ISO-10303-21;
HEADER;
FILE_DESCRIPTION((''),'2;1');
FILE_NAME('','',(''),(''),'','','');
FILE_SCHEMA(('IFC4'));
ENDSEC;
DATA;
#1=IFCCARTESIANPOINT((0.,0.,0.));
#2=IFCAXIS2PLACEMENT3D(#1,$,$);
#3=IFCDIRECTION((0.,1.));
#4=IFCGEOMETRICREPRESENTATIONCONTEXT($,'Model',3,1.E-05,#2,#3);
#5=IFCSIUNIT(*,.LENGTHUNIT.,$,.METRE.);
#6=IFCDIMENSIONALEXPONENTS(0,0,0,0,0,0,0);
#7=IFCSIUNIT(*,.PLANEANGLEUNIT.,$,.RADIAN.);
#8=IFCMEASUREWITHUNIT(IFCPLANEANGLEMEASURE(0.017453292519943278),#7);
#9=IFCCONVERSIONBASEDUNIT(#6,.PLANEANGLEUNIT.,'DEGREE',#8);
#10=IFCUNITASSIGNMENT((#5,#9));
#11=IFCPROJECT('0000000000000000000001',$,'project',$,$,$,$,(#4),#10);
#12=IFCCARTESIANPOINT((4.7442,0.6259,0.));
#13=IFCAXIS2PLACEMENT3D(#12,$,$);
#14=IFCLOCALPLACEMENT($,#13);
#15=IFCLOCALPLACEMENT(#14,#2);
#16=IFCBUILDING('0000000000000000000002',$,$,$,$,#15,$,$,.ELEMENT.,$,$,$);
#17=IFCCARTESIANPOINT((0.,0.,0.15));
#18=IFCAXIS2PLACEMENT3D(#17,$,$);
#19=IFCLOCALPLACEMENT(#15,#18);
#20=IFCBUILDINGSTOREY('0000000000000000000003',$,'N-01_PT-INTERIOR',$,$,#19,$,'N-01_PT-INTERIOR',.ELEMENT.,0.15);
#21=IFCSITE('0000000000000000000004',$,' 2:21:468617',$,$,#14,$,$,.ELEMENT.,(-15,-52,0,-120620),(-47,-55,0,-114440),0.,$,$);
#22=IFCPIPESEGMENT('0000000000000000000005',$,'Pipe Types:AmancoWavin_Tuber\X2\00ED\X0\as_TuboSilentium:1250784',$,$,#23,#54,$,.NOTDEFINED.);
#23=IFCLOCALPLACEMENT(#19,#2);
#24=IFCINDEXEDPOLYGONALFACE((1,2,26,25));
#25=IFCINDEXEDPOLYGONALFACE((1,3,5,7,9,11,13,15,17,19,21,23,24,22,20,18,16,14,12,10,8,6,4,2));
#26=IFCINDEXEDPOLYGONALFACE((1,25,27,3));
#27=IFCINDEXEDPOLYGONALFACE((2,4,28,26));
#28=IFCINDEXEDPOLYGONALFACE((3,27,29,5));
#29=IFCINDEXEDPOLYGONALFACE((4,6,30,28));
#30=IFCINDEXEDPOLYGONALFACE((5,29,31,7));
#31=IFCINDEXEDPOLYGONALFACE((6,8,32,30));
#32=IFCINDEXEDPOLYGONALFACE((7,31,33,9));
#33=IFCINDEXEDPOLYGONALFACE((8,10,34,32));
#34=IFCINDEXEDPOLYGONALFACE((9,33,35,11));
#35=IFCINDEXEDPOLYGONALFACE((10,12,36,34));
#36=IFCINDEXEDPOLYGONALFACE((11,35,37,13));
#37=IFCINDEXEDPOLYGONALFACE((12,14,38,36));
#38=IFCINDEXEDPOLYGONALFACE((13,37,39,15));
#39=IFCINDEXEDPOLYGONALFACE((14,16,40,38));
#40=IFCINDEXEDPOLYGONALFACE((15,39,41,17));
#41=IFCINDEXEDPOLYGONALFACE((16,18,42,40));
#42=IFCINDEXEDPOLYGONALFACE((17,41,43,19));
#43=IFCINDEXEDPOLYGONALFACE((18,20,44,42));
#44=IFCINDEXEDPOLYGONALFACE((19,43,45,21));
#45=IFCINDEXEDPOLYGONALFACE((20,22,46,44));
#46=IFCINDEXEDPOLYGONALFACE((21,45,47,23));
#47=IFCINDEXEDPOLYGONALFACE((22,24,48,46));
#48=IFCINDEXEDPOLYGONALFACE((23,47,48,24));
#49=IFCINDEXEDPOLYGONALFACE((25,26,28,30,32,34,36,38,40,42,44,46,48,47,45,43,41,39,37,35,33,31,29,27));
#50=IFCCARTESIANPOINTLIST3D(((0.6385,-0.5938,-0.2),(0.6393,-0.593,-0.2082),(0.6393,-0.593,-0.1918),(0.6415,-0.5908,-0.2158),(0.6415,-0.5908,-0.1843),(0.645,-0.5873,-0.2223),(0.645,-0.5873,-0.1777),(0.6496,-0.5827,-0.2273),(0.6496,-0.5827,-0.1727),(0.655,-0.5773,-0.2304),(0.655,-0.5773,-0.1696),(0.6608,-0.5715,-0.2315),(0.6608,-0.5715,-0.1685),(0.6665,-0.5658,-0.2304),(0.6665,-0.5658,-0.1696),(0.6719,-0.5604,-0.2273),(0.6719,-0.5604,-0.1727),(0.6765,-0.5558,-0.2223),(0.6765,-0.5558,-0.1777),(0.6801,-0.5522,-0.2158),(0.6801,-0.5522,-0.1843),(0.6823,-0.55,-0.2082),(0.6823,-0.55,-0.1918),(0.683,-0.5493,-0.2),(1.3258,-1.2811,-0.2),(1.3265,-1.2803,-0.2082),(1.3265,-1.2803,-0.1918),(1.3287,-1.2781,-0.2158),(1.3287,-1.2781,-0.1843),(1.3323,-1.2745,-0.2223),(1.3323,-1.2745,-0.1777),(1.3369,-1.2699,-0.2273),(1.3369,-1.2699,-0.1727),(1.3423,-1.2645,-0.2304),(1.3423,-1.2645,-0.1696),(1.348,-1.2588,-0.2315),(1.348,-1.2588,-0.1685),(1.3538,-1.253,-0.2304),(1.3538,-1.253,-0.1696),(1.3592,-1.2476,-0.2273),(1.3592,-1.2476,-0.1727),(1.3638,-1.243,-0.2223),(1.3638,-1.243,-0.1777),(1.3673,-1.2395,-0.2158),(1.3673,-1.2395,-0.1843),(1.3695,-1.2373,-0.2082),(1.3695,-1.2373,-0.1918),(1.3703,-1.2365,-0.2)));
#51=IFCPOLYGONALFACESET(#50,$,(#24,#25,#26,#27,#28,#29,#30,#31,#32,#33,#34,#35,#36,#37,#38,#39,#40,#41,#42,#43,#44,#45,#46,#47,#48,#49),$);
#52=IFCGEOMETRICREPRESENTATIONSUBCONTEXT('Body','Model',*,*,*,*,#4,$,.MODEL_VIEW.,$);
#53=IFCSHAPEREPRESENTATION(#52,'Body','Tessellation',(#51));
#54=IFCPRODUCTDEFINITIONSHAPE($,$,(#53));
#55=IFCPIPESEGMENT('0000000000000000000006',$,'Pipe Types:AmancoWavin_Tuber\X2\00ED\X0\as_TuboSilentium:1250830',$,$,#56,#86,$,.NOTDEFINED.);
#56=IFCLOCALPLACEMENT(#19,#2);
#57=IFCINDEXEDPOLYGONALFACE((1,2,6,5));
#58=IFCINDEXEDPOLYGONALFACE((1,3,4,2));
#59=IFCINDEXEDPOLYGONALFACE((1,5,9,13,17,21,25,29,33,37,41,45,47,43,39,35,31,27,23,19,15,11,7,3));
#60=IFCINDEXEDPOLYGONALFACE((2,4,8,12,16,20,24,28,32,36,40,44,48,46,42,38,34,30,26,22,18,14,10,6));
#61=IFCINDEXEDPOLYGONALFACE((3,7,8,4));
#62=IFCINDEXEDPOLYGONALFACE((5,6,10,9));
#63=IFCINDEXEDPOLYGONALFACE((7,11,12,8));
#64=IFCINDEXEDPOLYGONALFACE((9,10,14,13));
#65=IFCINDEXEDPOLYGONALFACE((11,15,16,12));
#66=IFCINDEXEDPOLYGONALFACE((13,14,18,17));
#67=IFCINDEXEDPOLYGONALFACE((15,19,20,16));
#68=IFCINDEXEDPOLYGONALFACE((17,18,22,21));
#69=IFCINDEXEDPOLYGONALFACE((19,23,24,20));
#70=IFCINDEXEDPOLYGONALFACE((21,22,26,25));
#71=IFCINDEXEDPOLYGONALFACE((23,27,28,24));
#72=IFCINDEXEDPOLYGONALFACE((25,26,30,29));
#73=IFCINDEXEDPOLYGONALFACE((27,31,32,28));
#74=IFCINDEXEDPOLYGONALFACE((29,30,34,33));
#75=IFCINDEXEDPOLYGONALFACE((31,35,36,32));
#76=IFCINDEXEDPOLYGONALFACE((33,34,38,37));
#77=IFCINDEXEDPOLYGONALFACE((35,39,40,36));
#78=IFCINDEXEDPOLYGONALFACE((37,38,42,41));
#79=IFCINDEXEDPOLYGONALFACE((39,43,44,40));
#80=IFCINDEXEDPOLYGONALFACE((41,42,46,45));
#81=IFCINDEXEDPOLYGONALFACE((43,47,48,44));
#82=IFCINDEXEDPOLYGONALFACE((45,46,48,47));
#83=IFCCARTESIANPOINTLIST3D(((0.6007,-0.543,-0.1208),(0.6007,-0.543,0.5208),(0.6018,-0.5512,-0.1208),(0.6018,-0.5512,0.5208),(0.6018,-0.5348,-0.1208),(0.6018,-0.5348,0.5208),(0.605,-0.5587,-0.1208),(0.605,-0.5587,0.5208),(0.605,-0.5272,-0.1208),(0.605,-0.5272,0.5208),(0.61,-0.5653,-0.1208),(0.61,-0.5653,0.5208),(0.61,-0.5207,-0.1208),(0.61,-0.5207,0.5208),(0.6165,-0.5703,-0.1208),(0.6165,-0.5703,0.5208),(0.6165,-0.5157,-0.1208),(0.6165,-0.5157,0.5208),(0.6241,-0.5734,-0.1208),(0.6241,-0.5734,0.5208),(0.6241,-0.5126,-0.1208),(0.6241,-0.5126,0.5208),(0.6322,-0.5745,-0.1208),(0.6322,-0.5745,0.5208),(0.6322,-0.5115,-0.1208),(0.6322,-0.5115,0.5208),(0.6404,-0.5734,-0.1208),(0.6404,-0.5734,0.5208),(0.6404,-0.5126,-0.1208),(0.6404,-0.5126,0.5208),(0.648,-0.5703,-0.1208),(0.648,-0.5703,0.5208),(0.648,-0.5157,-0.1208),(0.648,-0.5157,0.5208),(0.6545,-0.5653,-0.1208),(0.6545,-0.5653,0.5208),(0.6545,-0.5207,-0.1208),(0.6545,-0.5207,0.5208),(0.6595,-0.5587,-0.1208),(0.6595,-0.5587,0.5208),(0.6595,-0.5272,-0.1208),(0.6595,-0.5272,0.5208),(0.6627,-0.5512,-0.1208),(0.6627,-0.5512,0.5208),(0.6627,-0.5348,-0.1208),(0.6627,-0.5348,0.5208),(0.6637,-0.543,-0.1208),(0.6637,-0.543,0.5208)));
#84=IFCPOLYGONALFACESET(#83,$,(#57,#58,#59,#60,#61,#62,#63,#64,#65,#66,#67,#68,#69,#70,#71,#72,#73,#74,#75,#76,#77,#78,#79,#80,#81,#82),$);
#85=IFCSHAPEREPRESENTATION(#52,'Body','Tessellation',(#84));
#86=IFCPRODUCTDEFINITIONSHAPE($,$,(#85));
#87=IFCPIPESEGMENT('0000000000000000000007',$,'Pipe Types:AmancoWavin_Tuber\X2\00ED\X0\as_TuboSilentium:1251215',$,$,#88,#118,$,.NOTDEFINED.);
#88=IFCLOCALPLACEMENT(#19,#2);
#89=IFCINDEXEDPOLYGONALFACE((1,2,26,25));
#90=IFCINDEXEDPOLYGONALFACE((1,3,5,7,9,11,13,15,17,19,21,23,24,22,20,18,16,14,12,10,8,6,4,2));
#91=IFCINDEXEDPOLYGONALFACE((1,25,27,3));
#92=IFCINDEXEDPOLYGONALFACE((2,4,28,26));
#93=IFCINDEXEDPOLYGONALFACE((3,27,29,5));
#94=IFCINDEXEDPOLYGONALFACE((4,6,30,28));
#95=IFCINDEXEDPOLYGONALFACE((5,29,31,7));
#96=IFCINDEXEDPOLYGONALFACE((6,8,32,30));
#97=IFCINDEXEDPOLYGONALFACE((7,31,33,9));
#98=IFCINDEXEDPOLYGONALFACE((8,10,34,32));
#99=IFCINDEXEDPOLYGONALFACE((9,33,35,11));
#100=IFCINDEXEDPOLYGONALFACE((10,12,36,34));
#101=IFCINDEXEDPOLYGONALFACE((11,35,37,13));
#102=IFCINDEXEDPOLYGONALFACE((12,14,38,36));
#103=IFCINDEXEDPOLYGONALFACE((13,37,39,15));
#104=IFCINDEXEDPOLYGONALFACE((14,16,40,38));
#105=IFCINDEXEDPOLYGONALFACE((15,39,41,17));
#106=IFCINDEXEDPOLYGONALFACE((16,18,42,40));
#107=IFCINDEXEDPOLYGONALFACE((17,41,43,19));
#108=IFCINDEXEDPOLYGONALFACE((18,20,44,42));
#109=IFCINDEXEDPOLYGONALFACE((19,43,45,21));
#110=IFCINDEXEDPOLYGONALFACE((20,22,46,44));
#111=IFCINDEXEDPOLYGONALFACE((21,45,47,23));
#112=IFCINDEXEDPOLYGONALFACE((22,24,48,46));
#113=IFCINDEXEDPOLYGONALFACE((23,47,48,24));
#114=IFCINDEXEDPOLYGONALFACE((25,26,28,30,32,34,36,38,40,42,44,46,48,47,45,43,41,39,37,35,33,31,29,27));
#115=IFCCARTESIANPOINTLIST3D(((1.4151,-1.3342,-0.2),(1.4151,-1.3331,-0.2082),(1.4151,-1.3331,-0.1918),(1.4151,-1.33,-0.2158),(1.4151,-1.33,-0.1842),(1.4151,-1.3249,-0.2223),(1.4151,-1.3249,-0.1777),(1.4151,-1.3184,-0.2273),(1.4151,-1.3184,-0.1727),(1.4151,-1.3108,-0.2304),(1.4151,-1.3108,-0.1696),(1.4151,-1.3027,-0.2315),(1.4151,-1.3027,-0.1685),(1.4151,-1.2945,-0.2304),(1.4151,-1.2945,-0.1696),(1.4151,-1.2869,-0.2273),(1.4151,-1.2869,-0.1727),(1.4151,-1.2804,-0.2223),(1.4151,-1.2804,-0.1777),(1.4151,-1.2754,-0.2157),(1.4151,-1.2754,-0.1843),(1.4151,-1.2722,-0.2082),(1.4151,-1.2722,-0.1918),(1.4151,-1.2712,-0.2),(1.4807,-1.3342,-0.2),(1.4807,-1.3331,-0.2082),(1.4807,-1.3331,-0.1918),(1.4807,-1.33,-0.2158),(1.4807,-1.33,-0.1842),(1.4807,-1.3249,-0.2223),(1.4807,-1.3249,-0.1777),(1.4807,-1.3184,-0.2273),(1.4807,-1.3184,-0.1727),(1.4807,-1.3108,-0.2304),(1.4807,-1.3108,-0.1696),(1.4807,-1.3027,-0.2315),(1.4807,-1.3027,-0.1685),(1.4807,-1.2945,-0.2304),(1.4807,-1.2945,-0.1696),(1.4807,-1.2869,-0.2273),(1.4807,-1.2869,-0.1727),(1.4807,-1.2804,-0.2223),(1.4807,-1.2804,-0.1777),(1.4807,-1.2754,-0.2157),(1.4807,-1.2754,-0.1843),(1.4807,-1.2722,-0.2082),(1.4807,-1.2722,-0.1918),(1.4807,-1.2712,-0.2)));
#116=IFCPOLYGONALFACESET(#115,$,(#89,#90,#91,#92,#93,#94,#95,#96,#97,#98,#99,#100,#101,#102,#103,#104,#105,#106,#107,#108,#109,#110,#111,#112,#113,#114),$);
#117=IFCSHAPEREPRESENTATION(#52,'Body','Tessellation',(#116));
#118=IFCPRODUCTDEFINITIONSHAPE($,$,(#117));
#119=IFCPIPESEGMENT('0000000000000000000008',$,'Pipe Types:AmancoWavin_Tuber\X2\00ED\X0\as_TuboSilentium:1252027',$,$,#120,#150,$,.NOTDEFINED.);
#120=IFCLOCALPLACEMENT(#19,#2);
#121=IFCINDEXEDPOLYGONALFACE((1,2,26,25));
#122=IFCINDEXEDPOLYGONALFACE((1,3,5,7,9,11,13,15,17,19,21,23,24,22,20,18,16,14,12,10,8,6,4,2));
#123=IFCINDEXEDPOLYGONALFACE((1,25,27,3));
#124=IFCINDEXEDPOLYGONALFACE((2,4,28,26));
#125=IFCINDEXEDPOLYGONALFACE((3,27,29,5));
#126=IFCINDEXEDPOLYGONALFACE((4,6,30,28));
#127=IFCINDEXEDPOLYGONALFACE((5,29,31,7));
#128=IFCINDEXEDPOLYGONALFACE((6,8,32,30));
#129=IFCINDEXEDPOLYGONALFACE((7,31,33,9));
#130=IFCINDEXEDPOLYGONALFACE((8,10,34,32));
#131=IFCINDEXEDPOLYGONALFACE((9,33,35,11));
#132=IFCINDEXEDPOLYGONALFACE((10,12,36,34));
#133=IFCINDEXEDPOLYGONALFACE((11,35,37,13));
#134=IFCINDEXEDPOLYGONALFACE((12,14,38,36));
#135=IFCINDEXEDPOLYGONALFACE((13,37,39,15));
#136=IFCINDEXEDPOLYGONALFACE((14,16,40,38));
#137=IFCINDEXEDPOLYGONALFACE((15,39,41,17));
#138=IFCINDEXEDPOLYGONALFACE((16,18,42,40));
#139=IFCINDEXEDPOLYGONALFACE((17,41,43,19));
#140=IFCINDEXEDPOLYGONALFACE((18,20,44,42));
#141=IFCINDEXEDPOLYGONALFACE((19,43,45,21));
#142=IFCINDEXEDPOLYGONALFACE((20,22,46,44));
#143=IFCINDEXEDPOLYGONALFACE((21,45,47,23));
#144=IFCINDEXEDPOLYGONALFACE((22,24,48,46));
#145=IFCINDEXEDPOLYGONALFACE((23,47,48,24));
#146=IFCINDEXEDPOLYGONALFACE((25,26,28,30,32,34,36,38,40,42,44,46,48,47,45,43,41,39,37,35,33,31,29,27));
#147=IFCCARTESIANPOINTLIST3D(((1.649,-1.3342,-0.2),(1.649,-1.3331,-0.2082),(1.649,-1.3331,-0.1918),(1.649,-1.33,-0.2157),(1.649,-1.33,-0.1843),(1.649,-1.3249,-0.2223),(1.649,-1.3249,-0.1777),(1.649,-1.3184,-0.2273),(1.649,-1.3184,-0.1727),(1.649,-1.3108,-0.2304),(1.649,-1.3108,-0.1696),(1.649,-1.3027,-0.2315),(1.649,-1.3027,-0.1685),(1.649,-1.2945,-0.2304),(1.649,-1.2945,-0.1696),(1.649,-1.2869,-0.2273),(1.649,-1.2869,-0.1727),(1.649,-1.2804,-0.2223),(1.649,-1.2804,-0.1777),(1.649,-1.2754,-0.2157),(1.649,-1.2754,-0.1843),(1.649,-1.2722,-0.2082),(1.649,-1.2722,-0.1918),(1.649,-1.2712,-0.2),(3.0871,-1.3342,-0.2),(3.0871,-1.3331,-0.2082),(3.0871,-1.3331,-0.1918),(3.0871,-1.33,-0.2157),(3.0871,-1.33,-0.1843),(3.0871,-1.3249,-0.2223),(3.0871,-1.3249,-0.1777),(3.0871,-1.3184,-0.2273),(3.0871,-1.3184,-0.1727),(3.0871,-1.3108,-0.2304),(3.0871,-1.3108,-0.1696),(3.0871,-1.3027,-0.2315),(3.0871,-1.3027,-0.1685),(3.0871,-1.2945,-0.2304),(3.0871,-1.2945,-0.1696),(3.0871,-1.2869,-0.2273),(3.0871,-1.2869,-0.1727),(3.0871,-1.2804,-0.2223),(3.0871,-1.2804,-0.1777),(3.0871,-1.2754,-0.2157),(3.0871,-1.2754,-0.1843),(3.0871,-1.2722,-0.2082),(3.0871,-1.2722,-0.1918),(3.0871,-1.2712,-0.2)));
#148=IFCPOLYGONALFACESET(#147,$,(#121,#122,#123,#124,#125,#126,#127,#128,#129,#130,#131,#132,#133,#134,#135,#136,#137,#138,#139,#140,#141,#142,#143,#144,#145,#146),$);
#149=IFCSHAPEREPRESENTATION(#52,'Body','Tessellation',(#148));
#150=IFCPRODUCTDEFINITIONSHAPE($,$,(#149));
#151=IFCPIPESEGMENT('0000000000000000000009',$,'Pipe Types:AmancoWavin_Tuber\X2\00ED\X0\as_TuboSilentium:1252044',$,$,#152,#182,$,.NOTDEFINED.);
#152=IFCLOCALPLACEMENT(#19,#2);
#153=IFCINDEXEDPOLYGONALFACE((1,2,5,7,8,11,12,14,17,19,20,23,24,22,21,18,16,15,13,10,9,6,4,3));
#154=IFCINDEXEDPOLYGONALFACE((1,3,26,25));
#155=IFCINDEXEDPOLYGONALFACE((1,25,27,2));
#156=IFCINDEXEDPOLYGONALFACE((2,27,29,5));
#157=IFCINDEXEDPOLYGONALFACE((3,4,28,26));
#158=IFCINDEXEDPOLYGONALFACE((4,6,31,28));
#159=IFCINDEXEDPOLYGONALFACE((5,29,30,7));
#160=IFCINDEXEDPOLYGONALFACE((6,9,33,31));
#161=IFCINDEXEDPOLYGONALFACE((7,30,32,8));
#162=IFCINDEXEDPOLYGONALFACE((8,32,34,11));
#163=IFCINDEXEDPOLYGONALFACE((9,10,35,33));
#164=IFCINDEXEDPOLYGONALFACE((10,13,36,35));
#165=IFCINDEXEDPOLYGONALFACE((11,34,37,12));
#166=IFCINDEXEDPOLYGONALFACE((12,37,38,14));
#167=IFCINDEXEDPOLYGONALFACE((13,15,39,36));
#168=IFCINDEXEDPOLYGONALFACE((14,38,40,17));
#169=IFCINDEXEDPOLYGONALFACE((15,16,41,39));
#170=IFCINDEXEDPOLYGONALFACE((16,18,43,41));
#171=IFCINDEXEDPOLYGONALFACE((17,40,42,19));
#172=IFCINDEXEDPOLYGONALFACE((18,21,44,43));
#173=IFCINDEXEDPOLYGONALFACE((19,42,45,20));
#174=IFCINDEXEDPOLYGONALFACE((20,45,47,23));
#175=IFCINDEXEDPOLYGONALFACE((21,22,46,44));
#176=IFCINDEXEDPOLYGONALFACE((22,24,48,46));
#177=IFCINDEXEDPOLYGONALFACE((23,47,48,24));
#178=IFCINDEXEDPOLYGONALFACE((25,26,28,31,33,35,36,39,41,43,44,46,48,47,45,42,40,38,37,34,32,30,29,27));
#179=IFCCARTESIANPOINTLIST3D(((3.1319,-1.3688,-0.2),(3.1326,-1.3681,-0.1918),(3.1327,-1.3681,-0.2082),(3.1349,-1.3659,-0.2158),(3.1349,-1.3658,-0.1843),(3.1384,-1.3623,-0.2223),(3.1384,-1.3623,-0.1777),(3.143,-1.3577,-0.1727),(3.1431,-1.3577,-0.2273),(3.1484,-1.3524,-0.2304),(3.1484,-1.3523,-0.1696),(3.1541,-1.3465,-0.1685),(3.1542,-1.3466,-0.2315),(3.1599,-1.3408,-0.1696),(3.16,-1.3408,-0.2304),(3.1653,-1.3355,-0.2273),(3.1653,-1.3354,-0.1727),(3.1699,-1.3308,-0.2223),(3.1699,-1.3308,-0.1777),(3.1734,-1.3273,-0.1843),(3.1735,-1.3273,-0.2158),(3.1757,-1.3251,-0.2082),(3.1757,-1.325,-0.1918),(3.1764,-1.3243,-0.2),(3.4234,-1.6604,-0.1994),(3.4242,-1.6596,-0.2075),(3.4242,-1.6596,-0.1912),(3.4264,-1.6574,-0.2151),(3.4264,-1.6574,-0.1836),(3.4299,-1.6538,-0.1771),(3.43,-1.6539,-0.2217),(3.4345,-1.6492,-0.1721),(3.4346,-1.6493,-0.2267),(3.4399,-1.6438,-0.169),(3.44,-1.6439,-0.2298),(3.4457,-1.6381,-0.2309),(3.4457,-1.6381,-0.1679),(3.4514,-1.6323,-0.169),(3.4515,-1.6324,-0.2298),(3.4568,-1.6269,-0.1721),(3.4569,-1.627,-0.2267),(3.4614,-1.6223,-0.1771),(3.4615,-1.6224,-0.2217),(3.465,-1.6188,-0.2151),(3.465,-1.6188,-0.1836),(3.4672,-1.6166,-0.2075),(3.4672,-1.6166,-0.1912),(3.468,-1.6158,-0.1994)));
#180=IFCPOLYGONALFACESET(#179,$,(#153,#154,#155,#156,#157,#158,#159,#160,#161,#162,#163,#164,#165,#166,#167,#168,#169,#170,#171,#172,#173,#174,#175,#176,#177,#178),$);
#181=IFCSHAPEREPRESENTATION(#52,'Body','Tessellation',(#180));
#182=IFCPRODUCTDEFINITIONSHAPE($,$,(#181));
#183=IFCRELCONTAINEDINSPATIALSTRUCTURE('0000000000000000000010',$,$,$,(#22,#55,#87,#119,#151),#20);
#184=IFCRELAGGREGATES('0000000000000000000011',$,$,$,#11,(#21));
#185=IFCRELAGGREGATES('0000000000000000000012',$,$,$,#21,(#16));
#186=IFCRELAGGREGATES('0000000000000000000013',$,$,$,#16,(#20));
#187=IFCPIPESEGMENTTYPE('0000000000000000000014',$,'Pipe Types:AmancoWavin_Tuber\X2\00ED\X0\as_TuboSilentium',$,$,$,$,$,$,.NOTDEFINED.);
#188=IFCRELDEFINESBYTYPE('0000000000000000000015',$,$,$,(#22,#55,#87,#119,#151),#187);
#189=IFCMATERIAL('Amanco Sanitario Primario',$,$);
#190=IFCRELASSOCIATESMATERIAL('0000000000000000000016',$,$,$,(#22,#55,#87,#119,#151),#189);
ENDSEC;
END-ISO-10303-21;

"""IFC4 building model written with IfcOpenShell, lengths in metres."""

from ifc_helpers import new_model, entity, si_unit, converted_unit, direction, frame, origin, place, context, subcontext, project, spatial, arc, indexed_curve, outline, extrude, material, type_object, element, save


model = new_model("IFC4")

# Units and contexts
model_context = context("Model", 3, precision=1e-05, world=origin(), true_north=direction((0.0, 1.0)))
body_context = subcontext(model_context, "Body", "Model", "MODEL_VIEW")
ifc_project = project(units=[si_unit("LENGTHUNIT", "METRE"), converted_unit("PLANEANGLEUNIT", "DEGREE", entity("IfcPlaneAngleMeasure", 0.017453292519943278), si_unit("PLANEANGLEUNIT", "RADIAN"), dimensions=[0, 0, 0, 0, 0, 0, 0])], contexts=[model_context])

# Site, building, storey
site_placement = place(None, frame((4.7442, 0.6259, 0.0)))
site = spatial("IfcSite", under=ifc_project, at=site_placement, Name=" 2:21:468617", CompositionType="ELEMENT", RefLatitude=(-15, -52, 0, -120620), RefLongitude=(-47, -55, 0, -114440), RefElevation=0.0)
building_placement = place(site_placement, origin())
building = spatial("IfcBuilding", under=site, at=building_placement, CompositionType="ELEMENT")
storey_placement = place(building_placement, frame((0.0, 0.0, 0.15)))
storey = spatial("IfcBuildingStorey", under=building, at=storey_placement, Name="N-01_PT-INTERIOR", LongName="N-01_PT-INTERIOR", CompositionType="ELEMENT", Elevation=0.15)

# Pipe segments
pipe_segment_type_1 = type_object("IfcPipeSegmentType", Name="Pipe Types:AmancoWavin_Tuberías_TuboSilentium", PredefinedType="NOTDEFINED")
ifc_material_1 = material(Name="Amanco Sanitario Primario")
pipe_segment_1_placement = place(storey_placement, origin())
element("IfcPipeSegment", 1, at=pipe_segment_1_placement, inside=storey, type_object=pipe_segment_type_1, material=ifc_material_1, Name="Pipe Types:AmancoWavin_Tuberías_TuboSilentium:1250784", PredefinedType="NOTDEFINED", context=body_context, shape_type="SweptSolid", body=[
    extrude(outline(indexed_curve([(0.0315, 0.0), (0.0223, 0.0223), (0.0, 0.0315), (-0.0223, 0.0223), (-0.0315, 0.0), (-0.0223, -0.0223), (0.0, -0.0315), (0.0223, -0.0223)], segments=[arc(1, 2, 3), arc(3, 4, 5), arc(5, 6, 7), arc(7, 8, 1)], self_intersect=False)), frame((1.348, -1.2588, -0.2), z_axis=(-0.707107, 0.707107, 0.0), x_axis=(0.707107, 0.707107, 0.0)), (0.0, 0.0, 1.0), 0.9719),
])
pipe_segment_2_placement = place(storey_placement, origin())
element("IfcPipeSegment", 2, at=pipe_segment_2_placement, inside=storey, type_object=pipe_segment_type_1, material=ifc_material_1, Name="Pipe Types:AmancoWavin_Tuberías_TuboSilentium:1250830", PredefinedType="NOTDEFINED", context=body_context, shape_type="SweptSolid", body=[
    extrude(outline(indexed_curve([(0.0315, 0.0), (0.0223, 0.0223), (0.0, 0.0315), (-0.0223, 0.0223), (-0.0315, 0.0), (-0.0223, -0.0223), (0.0, -0.0315), (0.0223, -0.0223)], segments=[arc(1, 2, 3), arc(3, 4, 5), arc(5, 6, 7), arc(7, 8, 1)], self_intersect=False)), frame((0.6322, -0.543, -0.1208), z_axis=(0.0, 0.0, 1.0), x_axis=(-1.0, 0.0, 0.0)), (0.0, 0.0, 1.0), 0.6416),
])
pipe_segment_3_placement = place(storey_placement, origin())
element("IfcPipeSegment", 3, at=pipe_segment_3_placement, inside=storey, type_object=pipe_segment_type_1, material=ifc_material_1, Name="Pipe Types:AmancoWavin_Tuberías_TuboSilentium:1251215", PredefinedType="NOTDEFINED", context=body_context, shape_type="SweptSolid", body=[
    extrude(outline(indexed_curve([(0.0315, 0.0), (0.0223, 0.0223), (0.0, 0.0315), (-0.0223, 0.0223), (-0.0315, 0.0), (-0.0223, -0.0223), (0.0, -0.0315), (0.0223, -0.0223)], segments=[arc(1, 2, 3), arc(3, 4, 5), arc(5, 6, 7), arc(7, 8, 1)], self_intersect=False)), frame((1.4151, -1.3027, -0.2), z_axis=(1.0, 0.0, 0.0), x_axis=(0.0, 1.0, 0.0)), (0.0, 0.0, 1.0), 0.0656),
])
pipe_segment_4_placement = place(storey_placement, origin())
element("IfcPipeSegment", 4, at=pipe_segment_4_placement, inside=storey, type_object=pipe_segment_type_1, material=ifc_material_1, Name="Pipe Types:AmancoWavin_Tuberías_TuboSilentium:1252027", PredefinedType="NOTDEFINED", context=body_context, shape_type="SweptSolid", body=[
    extrude(outline(indexed_curve([(0.0315, 0.0), (0.0223, 0.0223), (0.0, 0.0315), (-0.0223, 0.0223), (-0.0315, 0.0), (-0.0223, -0.0223), (0.0, -0.0315), (0.0223, -0.0223)], segments=[arc(1, 2, 3), arc(3, 4, 5), arc(5, 6, 7), arc(7, 8, 1)], self_intersect=False)), frame((1.649, -1.3027, -0.2), z_axis=(1.0, 0.0, 0.0), x_axis=(0.0, -1.0, 0.0)), (0.0, 0.0, 1.0), 1.438),
])
pipe_segment_5_placement = place(storey_placement, origin())
element("IfcPipeSegment", 5, at=pipe_segment_5_placement, inside=storey, type_object=pipe_segment_type_1, material=ifc_material_1, Name="Pipe Types:AmancoWavin_Tuberías_TuboSilentium:1252044", PredefinedType="NOTDEFINED", context=body_context, shape_type="SweptSolid", body=[
    extrude(outline(indexed_curve([(0.0315, 0.0), (0.0223, 0.0223), (0.0, 0.0315), (-0.0223, 0.0223), (-0.0315, 0.0), (-0.0223, -0.0223), (0.0, -0.0315), (0.0223, -0.0223)], segments=[arc(1, 2, 3), arc(3, 4, 5), arc(5, 6, 7), arc(7, 8, 1)], self_intersect=False)), frame((3.1542, -1.3466, -0.2), z_axis=(0.707106, -0.707106, 0.001478), x_axis=(-0.707107, -0.707107, 0.0)), (0.0, 0.0, 1.0), 0.4123),
])

save(model, "model.ifc")
